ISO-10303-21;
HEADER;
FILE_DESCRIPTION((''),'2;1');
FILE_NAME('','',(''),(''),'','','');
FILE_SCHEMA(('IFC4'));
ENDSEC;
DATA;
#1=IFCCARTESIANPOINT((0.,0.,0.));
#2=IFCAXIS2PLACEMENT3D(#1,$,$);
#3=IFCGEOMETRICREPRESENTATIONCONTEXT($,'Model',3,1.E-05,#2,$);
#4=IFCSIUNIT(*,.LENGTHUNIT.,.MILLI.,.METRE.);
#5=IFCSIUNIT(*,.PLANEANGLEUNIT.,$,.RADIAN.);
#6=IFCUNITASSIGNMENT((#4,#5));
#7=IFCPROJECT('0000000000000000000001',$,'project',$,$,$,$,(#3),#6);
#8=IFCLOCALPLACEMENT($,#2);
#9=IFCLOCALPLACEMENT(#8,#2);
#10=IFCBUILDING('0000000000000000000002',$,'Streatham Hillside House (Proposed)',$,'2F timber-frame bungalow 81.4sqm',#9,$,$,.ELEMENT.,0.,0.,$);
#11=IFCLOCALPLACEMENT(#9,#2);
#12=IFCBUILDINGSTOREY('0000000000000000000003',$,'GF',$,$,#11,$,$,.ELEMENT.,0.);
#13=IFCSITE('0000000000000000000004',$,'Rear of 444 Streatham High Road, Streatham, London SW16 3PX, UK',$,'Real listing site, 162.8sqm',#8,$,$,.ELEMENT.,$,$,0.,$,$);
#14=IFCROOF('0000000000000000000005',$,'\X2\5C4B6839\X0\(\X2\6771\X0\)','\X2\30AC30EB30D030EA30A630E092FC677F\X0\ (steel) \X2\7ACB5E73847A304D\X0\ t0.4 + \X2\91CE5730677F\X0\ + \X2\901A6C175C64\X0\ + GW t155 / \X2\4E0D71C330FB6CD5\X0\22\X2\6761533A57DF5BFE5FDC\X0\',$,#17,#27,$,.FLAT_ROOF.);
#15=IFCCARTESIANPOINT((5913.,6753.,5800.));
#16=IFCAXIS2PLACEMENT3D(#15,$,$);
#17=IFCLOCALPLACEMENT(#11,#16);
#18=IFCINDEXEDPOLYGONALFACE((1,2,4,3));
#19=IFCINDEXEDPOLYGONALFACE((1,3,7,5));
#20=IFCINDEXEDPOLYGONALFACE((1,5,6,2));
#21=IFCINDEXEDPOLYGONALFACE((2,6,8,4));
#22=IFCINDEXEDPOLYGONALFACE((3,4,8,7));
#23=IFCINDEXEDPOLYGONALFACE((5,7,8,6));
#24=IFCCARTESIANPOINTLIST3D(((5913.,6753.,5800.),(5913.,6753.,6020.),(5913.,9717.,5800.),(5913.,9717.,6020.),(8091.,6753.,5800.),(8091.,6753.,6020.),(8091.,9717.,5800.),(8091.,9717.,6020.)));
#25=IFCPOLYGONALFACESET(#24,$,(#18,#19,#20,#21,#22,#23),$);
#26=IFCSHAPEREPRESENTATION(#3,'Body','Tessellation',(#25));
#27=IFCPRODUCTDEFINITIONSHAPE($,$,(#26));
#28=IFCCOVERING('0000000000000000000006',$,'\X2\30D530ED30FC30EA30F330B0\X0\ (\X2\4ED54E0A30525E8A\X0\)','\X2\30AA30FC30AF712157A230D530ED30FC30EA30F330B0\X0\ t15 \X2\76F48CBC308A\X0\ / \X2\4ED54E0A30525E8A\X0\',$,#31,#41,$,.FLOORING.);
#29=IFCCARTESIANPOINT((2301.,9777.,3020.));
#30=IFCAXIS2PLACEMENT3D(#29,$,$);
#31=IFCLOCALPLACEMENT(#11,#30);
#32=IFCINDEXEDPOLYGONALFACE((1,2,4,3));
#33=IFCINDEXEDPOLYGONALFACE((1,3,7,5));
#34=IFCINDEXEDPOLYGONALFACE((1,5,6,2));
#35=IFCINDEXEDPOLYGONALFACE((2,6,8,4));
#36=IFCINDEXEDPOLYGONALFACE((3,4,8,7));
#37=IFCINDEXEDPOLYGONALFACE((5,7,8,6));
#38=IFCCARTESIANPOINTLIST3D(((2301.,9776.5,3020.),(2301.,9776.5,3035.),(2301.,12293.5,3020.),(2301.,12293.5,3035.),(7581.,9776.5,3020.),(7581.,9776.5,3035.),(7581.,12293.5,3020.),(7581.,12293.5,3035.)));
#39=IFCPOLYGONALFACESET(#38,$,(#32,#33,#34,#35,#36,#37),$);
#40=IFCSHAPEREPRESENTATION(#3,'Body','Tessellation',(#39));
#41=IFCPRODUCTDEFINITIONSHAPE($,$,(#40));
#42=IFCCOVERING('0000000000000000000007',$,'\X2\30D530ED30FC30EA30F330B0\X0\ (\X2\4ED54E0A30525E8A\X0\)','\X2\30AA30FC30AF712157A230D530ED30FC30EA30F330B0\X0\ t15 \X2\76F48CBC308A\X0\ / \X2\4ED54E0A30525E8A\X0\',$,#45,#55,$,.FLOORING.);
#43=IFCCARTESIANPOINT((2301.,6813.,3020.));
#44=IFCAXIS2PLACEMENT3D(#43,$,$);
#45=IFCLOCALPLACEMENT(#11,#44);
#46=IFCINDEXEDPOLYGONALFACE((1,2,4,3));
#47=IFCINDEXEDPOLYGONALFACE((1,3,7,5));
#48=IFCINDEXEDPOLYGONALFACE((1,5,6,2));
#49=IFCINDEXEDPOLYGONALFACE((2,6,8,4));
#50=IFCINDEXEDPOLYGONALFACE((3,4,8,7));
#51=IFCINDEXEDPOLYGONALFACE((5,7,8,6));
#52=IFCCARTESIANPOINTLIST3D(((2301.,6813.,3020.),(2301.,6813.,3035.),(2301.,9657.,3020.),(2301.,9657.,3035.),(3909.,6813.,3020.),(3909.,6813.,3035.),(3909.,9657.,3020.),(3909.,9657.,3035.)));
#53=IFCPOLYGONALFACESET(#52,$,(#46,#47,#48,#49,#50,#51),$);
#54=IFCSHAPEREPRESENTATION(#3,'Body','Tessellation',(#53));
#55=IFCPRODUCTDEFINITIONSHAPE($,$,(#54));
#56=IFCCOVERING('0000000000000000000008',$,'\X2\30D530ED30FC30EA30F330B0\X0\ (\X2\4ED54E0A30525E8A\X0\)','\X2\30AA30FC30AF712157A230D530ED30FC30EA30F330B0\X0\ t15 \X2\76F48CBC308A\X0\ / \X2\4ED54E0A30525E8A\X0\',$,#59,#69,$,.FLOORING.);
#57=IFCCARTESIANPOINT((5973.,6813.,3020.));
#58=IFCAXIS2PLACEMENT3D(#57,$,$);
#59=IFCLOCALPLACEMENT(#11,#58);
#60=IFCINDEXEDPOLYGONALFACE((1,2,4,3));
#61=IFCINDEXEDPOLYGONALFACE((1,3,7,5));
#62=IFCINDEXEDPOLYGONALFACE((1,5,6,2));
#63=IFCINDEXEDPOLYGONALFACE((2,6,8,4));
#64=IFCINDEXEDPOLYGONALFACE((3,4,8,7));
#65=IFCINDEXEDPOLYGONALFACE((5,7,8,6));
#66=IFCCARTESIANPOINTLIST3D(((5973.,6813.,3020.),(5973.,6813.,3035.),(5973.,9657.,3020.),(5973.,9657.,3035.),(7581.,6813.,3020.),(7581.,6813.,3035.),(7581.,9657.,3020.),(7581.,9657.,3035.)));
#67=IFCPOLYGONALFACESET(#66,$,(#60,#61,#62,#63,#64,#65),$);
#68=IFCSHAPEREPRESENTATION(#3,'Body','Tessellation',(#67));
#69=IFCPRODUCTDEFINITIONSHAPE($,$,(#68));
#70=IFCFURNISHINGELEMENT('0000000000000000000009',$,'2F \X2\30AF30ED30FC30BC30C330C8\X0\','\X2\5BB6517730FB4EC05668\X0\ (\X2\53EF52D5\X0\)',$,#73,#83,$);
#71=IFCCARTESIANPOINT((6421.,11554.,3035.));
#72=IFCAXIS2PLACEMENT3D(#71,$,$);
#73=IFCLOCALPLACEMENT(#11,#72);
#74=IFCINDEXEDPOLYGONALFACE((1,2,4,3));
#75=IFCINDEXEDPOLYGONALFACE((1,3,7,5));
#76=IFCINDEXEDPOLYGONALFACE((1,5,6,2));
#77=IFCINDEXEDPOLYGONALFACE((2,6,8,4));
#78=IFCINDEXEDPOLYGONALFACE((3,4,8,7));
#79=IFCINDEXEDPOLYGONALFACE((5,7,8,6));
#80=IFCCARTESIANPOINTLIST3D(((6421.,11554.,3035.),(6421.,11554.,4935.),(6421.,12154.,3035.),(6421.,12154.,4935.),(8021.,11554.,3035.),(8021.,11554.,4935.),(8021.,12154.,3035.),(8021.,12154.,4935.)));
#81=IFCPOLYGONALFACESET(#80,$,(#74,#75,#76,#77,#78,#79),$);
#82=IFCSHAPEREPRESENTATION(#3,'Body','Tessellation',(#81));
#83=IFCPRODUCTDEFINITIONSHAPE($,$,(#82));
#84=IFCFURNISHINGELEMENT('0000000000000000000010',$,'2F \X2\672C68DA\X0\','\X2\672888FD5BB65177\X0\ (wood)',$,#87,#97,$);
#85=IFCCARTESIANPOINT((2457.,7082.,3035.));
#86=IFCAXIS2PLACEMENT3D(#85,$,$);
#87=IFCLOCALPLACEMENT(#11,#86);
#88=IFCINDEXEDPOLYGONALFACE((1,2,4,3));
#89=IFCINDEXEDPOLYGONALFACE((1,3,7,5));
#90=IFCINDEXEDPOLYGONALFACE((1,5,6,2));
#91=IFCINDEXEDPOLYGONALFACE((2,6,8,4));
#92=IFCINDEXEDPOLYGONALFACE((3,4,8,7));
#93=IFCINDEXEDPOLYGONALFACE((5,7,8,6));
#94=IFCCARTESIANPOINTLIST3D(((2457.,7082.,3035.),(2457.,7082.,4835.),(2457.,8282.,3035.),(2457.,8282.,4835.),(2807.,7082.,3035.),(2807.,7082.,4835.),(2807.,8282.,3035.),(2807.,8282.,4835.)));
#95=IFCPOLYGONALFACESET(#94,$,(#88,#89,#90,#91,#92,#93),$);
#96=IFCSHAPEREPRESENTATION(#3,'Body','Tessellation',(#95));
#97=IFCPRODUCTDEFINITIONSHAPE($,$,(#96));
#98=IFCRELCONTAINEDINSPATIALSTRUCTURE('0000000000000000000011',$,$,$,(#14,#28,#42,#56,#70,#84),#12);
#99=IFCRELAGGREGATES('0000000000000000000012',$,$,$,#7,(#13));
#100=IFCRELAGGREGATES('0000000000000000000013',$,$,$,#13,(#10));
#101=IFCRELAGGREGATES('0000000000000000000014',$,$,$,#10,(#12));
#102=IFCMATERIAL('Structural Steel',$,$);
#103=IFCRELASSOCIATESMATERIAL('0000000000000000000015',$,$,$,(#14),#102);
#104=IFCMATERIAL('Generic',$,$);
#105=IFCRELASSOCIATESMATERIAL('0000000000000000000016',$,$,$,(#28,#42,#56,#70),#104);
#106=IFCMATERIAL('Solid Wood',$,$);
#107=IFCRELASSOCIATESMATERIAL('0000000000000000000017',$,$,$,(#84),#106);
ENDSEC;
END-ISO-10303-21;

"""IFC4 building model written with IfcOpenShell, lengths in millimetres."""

from ifc_helpers import new_model, si_unit, frame, frame_2d, origin, place, context, project, spatial, rectangle, extrude, material, element, save


model = new_model("IFC4")

# Units and contexts
model_context = context("Model", 3, precision=1e-05, world=origin())
ifc_project = project(units=[si_unit("LENGTHUNIT", "METRE", prefix="MILLI"), si_unit("PLANEANGLEUNIT", "RADIAN")], contexts=[model_context])

# Site, building, storey
site_placement = place(None, origin())
site = spatial("IfcSite", under=ifc_project, at=site_placement, Name="Rear of 444 Streatham High Road, Streatham, London SW16 3PX, UK", ObjectType="Real listing site, 162.8sqm", CompositionType="ELEMENT", RefElevation=0.0)
building_placement = place(site_placement, origin())
building = spatial("IfcBuilding", under=site, at=building_placement, Name="Streatham Hillside House (Proposed)", ObjectType="2F timber-frame bungalow 81.4sqm", CompositionType="ELEMENT", ElevationOfRefHeight=0.0, ElevationOfTerrain=0.0)
storey_placement = place(building_placement, origin())
storey = spatial("IfcBuildingStorey", under=building, at=storey_placement, Name="GF", CompositionType="ELEMENT", Elevation=0.0)

# Shared definitions
ifc_material_1 = material(Name="Solid Wood")

# Roof
ifc_material_2 = material(Name="Structural Steel")
roof_1_placement = place(storey_placement, frame((5913.0, 6753.0, 5800.0)))
element("IfcRoof", 1, at=roof_1_placement, inside=storey, material=ifc_material_2, Name="屋根(東)", Description="ガルバリウム鋼板 (steel) 立平葺き t0.4 + 野地板 + 通気層 + GW t155 / 不燃・法22条区域対応", PredefinedType="FLAT_ROOF", context=model_context, shape_type="SweptSolid", body=[
    extrude(rectangle(XDim=2178.0, YDim=2964.0, at=frame_2d((1089.0, 1482.0))), frame((5913.0, 6753.0, 5800.0)), (0.0, 0.0, 1.0), 220.0),
])

# Coverings
ifc_material_3 = material(Name="Generic")
covering_1_placement = place(storey_placement, frame((2301.0, 9777.0, 3020.0)))
element("IfcCovering", 2, at=covering_1_placement, inside=storey, material=ifc_material_3, Name="フローリング (仕上げ床)", Description="オーク無垢フローリング t15 直貼り / 仕上げ床", PredefinedType="FLOORING", context=model_context, shape_type="SweptSolid", body=[
    extrude(rectangle(XDim=5280.0, YDim=2517.0, at=frame_2d((2640.0, 1258.0))), frame((2301.0, 9777.0, 3020.0)), (0.0, 0.0, 1.0), 15.0),
])
covering_2_placement = place(storey_placement, frame((2301.0, 6813.0, 3020.0)))
element("IfcCovering", 3, at=covering_2_placement, inside=storey, material=ifc_material_3, Name="フローリング (仕上げ床)", Description="オーク無垢フローリング t15 直貼り / 仕上げ床", PredefinedType="FLOORING", context=model_context, shape_type="SweptSolid", body=[
    extrude(rectangle(XDim=1608.0, YDim=2844.0, at=frame_2d((804.0, 1422.0))), frame((2301.0, 6813.0, 3020.0)), (0.0, 0.0, 1.0), 15.0),
])
covering_3_placement = place(storey_placement, frame((5973.0, 6813.0, 3020.0)))
element("IfcCovering", 4, at=covering_3_placement, inside=storey, material=ifc_material_3, Name="フローリング (仕上げ床)", Description="オーク無垢フローリング t15 直貼り / 仕上げ床", PredefinedType="FLOORING", context=model_context, shape_type="SweptSolid", body=[
    extrude(rectangle(XDim=1608.0, YDim=2844.0, at=frame_2d((804.0, 1422.0))), frame((5973.0, 6813.0, 3020.0)), (0.0, 0.0, 1.0), 15.0),
])

# Furnishing elements
furnishing_1_placement = place(storey_placement, frame((6421.0, 11554.0, 3035.0)))
element("IfcFurnishingElement", 5, at=furnishing_1_placement, inside=storey, material=ifc_material_3, Name="2F クローゼット", Description="家具・什器 (可動)", context=model_context, shape_type="SweptSolid", body=[
    extrude(rectangle(XDim=1600.0, YDim=600.0, at=frame_2d((800.0, 300.0))), frame((6421.0, 11554.0, 3035.0)), (0.0, 0.0, 1.0), 1900.0),
])
furnishing_2_placement = place(storey_placement, frame((2457.0, 7082.0, 3035.0)))
element("IfcFurnishingElement", 6, at=furnishing_2_placement, inside=storey, material=ifc_material_1, Name="2F 本棚", Description="木製家具 (wood)", context=model_context, shape_type="SweptSolid", body=[
    extrude(rectangle(XDim=350.0, YDim=1200.0, at=frame_2d((175.0, 600.0))), frame((2457.0, 7082.0, 3035.0)), (0.0, 0.0, 1.0), 1800.0),
])

save(model, "model.ifc")
